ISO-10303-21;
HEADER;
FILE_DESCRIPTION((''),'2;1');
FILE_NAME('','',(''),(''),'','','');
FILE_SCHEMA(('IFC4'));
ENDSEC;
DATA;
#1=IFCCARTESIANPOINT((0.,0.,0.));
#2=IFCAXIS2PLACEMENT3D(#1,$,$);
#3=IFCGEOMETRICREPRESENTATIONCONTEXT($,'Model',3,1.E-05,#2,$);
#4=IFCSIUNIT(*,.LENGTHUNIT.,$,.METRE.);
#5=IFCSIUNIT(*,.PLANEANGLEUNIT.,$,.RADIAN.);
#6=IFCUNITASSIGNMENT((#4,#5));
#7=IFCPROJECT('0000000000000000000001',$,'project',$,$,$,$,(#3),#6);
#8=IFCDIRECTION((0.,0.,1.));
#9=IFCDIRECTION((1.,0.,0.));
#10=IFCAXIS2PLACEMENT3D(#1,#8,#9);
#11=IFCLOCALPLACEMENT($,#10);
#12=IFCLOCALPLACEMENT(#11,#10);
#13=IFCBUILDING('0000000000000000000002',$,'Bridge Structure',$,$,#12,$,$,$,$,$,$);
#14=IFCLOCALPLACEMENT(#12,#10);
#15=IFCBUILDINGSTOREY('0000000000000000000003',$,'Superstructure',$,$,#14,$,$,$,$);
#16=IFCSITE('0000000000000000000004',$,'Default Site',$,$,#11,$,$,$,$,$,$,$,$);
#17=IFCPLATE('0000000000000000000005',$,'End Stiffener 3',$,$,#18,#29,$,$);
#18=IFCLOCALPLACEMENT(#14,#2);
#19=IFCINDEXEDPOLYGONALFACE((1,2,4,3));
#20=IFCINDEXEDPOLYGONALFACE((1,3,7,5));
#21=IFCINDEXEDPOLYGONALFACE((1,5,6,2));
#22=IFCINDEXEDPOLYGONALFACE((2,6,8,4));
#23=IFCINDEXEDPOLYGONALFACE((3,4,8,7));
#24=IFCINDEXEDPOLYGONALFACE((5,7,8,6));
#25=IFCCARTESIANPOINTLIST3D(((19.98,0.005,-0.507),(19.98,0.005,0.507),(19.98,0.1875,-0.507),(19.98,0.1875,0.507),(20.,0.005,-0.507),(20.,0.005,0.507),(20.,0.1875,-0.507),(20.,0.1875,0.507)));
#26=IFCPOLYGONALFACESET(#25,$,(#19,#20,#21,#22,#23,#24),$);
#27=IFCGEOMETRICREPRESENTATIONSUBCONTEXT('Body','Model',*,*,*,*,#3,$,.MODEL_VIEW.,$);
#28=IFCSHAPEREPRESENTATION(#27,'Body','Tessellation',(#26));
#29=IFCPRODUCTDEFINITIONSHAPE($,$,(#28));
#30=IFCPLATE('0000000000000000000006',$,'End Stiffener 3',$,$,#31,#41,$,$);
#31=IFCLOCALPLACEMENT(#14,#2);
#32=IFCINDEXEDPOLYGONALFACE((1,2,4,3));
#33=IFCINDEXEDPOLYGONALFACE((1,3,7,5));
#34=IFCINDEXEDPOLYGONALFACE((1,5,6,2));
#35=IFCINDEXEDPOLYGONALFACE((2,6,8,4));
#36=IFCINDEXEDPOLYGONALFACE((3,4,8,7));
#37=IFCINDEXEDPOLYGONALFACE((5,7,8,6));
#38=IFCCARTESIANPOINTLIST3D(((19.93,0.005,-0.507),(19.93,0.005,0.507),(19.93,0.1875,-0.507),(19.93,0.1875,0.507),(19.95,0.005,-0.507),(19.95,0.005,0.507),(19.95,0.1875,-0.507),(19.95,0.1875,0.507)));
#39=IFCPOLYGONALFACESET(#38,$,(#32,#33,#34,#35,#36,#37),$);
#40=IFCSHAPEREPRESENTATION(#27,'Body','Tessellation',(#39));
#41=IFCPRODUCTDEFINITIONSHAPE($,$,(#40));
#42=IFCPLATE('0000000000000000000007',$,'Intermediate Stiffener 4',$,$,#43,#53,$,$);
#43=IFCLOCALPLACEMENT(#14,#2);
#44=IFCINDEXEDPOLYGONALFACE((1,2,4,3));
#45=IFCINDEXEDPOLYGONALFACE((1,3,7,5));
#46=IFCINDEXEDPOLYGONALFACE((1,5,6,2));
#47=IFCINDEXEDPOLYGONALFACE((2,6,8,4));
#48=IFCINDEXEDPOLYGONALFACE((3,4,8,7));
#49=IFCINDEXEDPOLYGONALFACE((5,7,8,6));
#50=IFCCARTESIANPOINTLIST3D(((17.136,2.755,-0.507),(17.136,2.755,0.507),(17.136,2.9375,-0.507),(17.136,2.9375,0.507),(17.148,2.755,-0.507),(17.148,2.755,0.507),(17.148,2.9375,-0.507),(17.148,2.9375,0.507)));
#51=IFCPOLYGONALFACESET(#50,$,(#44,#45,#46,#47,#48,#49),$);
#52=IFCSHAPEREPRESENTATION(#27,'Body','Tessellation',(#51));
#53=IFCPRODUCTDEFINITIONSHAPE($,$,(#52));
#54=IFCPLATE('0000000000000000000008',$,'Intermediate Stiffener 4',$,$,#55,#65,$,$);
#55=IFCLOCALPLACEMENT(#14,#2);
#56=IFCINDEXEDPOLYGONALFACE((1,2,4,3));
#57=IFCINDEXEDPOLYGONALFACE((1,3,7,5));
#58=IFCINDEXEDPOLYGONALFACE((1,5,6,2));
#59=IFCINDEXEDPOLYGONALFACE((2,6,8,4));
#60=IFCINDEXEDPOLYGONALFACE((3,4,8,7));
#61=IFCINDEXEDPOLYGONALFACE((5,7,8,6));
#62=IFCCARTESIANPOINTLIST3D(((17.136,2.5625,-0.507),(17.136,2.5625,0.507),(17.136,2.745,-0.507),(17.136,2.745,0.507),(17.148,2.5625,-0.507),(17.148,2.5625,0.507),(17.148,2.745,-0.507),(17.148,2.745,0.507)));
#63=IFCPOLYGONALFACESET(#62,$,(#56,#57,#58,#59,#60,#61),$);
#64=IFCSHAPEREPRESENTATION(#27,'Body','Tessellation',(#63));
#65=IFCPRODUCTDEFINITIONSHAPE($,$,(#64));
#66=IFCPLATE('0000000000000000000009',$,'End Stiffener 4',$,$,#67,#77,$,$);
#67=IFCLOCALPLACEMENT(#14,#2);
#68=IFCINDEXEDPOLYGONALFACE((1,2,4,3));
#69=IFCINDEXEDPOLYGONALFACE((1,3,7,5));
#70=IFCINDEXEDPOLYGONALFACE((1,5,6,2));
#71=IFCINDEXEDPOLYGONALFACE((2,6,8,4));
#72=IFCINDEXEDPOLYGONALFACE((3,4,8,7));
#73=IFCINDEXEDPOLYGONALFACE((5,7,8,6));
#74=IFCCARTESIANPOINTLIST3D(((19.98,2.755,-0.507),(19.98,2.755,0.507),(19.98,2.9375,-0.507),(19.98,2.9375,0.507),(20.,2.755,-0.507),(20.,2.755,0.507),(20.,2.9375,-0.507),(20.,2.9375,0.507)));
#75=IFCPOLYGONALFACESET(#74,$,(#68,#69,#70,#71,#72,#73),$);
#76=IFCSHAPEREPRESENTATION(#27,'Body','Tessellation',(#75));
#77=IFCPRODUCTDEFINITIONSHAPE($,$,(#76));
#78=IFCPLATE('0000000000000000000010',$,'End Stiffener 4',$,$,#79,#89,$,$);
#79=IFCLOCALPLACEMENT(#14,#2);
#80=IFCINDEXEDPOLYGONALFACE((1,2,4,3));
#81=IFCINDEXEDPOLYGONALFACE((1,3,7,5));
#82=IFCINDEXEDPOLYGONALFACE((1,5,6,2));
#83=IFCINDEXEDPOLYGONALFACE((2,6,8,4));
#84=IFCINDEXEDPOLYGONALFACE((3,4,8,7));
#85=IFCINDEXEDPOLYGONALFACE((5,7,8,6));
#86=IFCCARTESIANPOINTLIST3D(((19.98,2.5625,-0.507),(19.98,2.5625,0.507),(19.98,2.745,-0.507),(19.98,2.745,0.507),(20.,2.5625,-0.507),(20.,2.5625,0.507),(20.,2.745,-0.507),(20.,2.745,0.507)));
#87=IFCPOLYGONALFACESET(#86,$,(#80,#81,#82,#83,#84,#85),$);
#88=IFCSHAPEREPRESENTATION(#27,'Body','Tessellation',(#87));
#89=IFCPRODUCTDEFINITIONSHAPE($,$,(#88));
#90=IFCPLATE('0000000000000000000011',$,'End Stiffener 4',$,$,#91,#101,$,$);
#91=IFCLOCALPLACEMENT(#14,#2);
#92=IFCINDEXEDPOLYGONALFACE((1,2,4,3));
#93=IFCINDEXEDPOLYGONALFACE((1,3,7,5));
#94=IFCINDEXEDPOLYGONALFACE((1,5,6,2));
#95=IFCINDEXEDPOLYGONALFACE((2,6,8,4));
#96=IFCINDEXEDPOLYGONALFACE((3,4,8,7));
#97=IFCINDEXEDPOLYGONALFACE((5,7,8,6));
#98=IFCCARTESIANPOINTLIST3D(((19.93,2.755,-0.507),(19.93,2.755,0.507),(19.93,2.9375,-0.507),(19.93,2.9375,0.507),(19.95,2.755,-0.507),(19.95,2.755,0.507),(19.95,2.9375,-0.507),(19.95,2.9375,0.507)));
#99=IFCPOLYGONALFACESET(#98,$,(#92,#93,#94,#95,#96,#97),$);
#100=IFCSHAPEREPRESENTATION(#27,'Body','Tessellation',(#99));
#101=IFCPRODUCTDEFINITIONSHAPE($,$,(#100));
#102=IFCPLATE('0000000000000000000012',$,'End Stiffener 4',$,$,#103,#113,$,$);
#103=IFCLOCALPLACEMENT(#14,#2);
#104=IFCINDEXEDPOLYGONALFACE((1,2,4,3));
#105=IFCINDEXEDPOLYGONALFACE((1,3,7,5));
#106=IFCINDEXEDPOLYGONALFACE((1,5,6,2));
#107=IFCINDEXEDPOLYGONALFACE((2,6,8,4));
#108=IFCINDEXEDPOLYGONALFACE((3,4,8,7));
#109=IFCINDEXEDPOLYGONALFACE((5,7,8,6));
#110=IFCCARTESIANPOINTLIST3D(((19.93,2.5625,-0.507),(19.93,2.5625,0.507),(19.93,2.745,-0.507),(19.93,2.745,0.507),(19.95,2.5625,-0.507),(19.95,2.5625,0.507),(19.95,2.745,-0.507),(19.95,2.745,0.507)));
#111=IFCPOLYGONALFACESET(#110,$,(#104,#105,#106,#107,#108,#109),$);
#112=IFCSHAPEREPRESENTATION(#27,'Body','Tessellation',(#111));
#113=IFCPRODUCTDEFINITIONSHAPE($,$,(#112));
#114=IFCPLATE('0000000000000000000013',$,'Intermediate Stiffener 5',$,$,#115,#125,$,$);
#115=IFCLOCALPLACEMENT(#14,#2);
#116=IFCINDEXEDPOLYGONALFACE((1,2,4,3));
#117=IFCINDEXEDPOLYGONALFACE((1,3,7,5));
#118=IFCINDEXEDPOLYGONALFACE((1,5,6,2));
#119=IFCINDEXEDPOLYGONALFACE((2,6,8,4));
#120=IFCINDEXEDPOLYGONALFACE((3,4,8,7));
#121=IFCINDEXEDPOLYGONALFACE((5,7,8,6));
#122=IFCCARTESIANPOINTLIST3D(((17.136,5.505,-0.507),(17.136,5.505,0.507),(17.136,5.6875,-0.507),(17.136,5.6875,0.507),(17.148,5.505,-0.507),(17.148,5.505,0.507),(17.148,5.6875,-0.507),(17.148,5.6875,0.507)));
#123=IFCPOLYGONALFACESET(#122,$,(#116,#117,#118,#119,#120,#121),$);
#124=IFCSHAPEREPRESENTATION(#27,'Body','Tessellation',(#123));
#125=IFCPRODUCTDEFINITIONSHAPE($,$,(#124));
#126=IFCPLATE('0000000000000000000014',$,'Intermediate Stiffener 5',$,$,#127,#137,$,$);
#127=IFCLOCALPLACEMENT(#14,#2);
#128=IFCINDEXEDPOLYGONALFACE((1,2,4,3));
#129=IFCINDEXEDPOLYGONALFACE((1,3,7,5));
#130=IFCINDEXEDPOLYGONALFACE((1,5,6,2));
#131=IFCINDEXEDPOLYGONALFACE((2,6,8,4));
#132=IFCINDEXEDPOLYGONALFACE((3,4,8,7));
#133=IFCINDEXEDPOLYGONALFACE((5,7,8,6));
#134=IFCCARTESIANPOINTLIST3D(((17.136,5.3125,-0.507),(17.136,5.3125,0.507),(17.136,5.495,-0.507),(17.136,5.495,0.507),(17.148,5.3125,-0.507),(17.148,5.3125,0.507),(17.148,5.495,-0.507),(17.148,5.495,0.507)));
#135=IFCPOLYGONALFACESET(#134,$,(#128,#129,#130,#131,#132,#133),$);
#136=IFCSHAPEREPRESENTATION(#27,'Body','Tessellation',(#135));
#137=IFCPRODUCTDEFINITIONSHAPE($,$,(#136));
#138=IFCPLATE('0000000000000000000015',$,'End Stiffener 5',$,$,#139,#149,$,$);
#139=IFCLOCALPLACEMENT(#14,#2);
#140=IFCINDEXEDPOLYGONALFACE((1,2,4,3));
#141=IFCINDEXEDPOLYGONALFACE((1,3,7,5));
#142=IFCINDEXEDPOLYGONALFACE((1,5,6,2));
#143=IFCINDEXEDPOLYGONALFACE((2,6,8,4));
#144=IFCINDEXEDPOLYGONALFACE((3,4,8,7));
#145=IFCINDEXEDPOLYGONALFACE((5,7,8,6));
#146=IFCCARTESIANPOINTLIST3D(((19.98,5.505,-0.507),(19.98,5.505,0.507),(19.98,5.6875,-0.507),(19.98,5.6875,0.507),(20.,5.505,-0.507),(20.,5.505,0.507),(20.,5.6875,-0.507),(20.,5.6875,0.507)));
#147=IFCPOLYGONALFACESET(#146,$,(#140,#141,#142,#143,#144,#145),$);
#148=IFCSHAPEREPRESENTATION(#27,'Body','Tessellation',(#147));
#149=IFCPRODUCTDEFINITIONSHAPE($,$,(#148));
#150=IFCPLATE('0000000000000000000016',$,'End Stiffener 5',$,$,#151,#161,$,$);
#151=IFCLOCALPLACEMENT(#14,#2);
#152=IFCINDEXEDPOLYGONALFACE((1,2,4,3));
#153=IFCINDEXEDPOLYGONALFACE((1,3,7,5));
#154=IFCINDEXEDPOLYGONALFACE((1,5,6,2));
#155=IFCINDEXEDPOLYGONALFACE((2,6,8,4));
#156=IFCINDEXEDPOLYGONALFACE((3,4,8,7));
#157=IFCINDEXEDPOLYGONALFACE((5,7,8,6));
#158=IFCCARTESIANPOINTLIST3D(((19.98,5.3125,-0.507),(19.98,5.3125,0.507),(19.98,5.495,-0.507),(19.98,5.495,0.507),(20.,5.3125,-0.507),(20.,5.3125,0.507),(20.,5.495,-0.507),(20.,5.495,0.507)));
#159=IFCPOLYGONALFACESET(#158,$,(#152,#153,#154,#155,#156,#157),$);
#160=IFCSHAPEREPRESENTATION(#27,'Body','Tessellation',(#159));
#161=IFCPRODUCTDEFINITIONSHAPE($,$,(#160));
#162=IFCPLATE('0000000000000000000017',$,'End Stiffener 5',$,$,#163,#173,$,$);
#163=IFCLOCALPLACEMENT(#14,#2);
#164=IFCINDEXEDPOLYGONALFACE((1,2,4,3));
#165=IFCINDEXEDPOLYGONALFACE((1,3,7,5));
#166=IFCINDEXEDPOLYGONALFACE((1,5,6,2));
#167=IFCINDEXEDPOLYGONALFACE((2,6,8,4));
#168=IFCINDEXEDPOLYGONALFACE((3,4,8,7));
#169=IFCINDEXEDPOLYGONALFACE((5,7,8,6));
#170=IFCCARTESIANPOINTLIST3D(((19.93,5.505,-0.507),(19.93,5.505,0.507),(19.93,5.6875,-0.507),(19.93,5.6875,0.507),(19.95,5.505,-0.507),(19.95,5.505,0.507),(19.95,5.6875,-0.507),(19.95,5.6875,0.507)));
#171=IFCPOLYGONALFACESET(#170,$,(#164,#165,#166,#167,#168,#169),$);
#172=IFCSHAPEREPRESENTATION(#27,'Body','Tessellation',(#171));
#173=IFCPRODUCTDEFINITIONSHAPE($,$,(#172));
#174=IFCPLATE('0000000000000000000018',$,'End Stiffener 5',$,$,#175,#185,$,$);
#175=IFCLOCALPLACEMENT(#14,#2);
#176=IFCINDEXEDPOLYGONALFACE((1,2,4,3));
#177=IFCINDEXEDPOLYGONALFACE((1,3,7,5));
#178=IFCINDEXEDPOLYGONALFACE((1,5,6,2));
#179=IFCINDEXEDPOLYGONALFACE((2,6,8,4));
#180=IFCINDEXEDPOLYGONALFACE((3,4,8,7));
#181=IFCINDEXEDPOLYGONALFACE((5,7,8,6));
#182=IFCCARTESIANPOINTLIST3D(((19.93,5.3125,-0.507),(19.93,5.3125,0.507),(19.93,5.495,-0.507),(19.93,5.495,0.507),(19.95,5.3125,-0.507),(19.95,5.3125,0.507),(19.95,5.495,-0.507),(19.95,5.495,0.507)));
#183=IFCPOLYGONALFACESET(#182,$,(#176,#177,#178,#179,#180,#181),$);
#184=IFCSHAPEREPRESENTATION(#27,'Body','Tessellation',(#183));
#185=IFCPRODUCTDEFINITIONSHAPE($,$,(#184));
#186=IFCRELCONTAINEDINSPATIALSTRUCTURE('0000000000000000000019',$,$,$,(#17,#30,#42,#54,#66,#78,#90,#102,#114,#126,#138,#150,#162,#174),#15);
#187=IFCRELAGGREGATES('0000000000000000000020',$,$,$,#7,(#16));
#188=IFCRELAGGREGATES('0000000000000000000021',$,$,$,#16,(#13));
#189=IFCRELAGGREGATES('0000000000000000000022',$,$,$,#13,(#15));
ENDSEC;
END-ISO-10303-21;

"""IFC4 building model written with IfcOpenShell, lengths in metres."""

from ifc_helpers import new_model, si_unit, frame, origin, origin_with_axes, origin_2d_with_axis, place, context, subcontext, project, spatial, rectangle, extrude, element, save


model = new_model("IFC4")

# Units and contexts
model_context = context("Model", 3, precision=1e-05, world=origin())
body_context = subcontext(model_context, "Body", "Model", "MODEL_VIEW")
ifc_project = project(units=[si_unit("LENGTHUNIT", "METRE"), si_unit("PLANEANGLEUNIT", "RADIAN")], contexts=[model_context])

# Site, building, storey
site_placement = place(None, origin_with_axes())
site = spatial("IfcSite", under=ifc_project, at=site_placement, Name="Default Site")
building_placement = place(site_placement, origin_with_axes())
building = spatial("IfcBuilding", under=site, at=building_placement, Name="Bridge Structure")
storey_placement = place(building_placement, origin_with_axes())
storey = spatial("IfcBuildingStorey", under=building, at=storey_placement, Name="Superstructure")

# Plates
for number, where, z_axis, x_axis, name in (
    (1, (19.99, 0.0963, -0.507), (0.0, 0.0, 1.0), (1.0, 0.0, 0.0), "End Stiffener 3"),
    (2, (19.94, 0.0963, -0.507), (0.0, 0.0, 1.0), (1.0, 0.0, 0.0), "End Stiffener 3"),
):
    element("IfcPlate", number, at=place(storey_placement, frame(where, z_axis=z_axis, x_axis=x_axis)), inside=storey, Name=name, context=body_context, shape_type="SweptSolid", body=[
        extrude(rectangle(XDim=0.02, YDim=0.1825, at=origin_2d_with_axis()), origin_with_axes(), (0.0, 0.0, 1.0), 1.014),
    ])
for number, where, z_axis, x_axis, name in (
    (3, (17.142, 2.8462, -0.507), (0.0, 0.0, 1.0), (1.0, 0.0, 0.0), "Intermediate Stiffener 4"),
    (4, (17.142, 2.6538, -0.507), (0.0, 0.0, 1.0), (1.0, 0.0, 0.0), "Intermediate Stiffener 4"),
):
    element("IfcPlate", number, at=place(storey_placement, frame(where, z_axis=z_axis, x_axis=x_axis)), inside=storey, Name=name, context=body_context, shape_type="SweptSolid", body=[
        extrude(rectangle(XDim=0.012, YDim=0.1825, at=origin_2d_with_axis()), origin_with_axes(), (0.0, 0.0, 1.0), 1.014),
    ])
for number, where, z_axis, x_axis, name in (
    (5, (19.99, 2.8462, -0.507), (0.0, 0.0, 1.0), (1.0, 0.0, 0.0), "End Stiffener 4"),
    (6, (19.99, 2.6538, -0.507), (0.0, 0.0, 1.0), (1.0, 0.0, 0.0), "End Stiffener 4"),
    (7, (19.94, 2.8462, -0.507), (0.0, 0.0, 1.0), (1.0, 0.0, 0.0), "End Stiffener 4"),
    (8, (19.94, 2.6538, -0.507), (0.0, 0.0, 1.0), (1.0, 0.0, 0.0), "End Stiffener 4"),
):
    element("IfcPlate", number, at=place(storey_placement, frame(where, z_axis=z_axis, x_axis=x_axis)), inside=storey, Name=name, context=body_context, shape_type="SweptSolid", body=[
        extrude(rectangle(XDim=0.02, YDim=0.1825, at=origin_2d_with_axis()), origin_with_axes(), (0.0, 0.0, 1.0), 1.014),
    ])
for number, where, z_axis, x_axis, name in (
    (9, (17.142, 5.5963, -0.507), (0.0, 0.0, 1.0), (1.0, 0.0, 0.0), "Intermediate Stiffener 5"),
    (10, (17.142, 5.4038, -0.507), (0.0, 0.0, 1.0), (1.0, 0.0, 0.0), "Intermediate Stiffener 5"),
):
    element("IfcPlate", number, at=place(storey_placement, frame(where, z_axis=z_axis, x_axis=x_axis)), inside=storey, Name=name, context=body_context, shape_type="SweptSolid", body=[
        extrude(rectangle(XDim=0.012, YDim=0.1825, at=origin_2d_with_axis()), origin_with_axes(), (0.0, 0.0, 1.0), 1.014),
    ])
for number, where, z_axis, x_axis, name in (
    (11, (19.99, 5.5963, -0.507), (0.0, 0.0, 1.0), (1.0, 0.0, 0.0), "End Stiffener 5"),
    (12, (19.99, 5.4038, -0.507), (0.0, 0.0, 1.0), (1.0, 0.0, 0.0), "End Stiffener 5"),
    (13, (19.94, 5.5963, -0.507), (0.0, 0.0, 1.0), (1.0, 0.0, 0.0), "End Stiffener 5"),
    (14, (19.94, 5.4038, -0.507), (0.0, 0.0, 1.0), (1.0, 0.0, 0.0), "End Stiffener 5"),
):
    element("IfcPlate", number, at=place(storey_placement, frame(where, z_axis=z_axis, x_axis=x_axis)), inside=storey, Name=name, context=body_context, shape_type="SweptSolid", body=[
        extrude(rectangle(XDim=0.02, YDim=0.1825, at=origin_2d_with_axis()), origin_with_axes(), (0.0, 0.0, 1.0), 1.014),
    ])

save(model, "model.ifc")
